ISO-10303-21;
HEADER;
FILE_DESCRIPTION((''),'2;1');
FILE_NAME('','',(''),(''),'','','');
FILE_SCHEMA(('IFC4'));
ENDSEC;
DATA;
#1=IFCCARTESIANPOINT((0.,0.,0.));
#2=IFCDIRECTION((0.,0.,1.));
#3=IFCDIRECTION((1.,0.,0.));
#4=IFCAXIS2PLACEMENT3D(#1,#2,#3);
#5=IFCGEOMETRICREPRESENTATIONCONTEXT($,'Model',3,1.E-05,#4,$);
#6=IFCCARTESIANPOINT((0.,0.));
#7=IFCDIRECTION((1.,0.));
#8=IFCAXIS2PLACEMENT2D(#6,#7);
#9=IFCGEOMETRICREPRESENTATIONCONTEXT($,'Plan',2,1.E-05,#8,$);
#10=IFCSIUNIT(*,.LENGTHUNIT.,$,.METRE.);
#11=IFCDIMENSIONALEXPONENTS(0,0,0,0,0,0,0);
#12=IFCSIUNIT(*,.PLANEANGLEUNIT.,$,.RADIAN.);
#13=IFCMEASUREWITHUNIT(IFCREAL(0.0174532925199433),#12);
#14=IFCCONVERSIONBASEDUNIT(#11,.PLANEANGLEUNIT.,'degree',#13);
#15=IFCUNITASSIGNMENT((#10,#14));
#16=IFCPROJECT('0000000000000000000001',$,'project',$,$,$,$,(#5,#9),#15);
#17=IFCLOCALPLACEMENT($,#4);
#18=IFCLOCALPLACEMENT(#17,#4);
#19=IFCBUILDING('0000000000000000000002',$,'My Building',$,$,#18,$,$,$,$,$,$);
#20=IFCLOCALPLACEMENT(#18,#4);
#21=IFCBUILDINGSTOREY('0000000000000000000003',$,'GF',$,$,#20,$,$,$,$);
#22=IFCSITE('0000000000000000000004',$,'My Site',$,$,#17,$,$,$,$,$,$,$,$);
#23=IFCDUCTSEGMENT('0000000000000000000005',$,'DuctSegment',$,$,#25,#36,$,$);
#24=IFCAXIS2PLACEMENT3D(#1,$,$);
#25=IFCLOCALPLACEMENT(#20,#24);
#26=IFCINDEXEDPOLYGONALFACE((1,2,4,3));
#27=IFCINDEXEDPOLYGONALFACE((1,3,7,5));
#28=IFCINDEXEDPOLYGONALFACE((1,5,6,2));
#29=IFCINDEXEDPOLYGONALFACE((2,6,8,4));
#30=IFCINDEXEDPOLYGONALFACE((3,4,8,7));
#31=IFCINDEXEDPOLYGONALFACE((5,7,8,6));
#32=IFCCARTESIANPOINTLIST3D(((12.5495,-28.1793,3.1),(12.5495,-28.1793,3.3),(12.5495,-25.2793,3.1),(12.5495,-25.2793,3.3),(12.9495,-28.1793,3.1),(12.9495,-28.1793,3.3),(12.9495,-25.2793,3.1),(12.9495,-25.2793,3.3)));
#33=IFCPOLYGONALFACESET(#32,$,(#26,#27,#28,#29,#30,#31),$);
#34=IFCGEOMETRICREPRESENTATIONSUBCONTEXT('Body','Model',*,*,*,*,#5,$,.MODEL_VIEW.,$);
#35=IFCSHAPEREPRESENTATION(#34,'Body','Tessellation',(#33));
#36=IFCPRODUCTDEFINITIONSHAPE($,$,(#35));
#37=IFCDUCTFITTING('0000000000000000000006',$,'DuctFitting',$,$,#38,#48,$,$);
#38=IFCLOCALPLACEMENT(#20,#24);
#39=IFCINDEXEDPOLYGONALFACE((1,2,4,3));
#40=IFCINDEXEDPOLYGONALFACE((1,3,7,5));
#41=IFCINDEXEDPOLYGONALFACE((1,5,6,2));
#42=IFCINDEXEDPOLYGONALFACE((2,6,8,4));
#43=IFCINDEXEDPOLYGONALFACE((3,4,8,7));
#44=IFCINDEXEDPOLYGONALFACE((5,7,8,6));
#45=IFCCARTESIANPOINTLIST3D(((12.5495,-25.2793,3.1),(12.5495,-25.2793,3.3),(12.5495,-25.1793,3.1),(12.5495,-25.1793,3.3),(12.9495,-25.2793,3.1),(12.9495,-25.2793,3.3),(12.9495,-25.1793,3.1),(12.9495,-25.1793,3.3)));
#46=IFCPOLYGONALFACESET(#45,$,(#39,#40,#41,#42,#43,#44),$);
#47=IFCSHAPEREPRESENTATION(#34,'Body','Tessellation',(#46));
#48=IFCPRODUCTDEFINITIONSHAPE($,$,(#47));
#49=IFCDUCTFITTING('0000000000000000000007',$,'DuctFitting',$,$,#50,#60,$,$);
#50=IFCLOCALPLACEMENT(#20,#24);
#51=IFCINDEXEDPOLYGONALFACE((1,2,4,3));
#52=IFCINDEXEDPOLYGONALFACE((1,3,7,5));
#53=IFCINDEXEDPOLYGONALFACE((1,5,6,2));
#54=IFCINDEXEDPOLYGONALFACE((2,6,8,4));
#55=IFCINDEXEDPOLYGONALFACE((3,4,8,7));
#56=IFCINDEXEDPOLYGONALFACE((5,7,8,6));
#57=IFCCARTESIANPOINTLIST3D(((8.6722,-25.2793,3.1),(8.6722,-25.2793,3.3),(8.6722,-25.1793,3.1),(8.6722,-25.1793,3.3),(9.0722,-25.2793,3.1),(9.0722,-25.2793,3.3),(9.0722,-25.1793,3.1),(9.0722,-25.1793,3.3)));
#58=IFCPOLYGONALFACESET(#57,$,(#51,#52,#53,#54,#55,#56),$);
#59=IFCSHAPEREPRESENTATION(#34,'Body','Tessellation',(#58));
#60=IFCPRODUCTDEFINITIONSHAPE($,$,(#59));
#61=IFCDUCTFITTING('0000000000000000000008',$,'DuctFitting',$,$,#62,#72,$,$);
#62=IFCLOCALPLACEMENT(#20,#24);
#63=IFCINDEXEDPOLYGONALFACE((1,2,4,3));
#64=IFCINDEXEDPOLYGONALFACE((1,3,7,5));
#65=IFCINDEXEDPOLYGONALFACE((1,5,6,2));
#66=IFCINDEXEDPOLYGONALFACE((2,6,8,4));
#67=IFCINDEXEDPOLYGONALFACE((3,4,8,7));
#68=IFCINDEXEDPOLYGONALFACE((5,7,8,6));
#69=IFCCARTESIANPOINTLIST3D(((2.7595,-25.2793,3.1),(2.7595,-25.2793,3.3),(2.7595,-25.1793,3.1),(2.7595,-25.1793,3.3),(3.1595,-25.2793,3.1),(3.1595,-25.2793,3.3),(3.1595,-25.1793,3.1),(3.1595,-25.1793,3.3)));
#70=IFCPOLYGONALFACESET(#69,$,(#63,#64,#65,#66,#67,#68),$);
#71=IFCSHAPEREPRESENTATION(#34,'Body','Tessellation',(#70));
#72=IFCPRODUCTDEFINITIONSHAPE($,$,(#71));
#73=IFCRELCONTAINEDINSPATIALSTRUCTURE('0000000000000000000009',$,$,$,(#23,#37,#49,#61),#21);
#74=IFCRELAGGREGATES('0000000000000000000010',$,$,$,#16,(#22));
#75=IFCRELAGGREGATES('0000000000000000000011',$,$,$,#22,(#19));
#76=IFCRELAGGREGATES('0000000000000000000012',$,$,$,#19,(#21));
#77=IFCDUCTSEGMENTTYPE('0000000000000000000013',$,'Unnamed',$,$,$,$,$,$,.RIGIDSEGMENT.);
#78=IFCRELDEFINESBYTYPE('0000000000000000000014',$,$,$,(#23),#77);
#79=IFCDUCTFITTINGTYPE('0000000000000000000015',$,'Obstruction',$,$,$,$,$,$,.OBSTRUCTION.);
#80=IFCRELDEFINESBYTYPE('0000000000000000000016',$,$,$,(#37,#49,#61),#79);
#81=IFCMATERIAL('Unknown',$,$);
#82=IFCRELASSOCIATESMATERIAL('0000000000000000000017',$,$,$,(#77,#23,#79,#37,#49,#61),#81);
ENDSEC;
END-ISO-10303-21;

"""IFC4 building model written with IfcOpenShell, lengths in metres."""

from ifc_helpers import new_model, entity, si_unit, converted_unit, frame, origin_with_axes, origin_2d_with_axis, place, context, subcontext, project, spatial, rectangle, extrude, material, material_profile, profile_set, profile_usage, type_object, element, save


model = new_model("IFC4")

# Units and contexts
model_context = context("Model", 3, precision=1e-05, world=origin_with_axes())
plan_context = context("Plan", 2, precision=1e-05, world=origin_2d_with_axis())
body_context_1 = subcontext(model_context, "Body", "Model", "MODEL_VIEW")
ifc_project = project(units=[si_unit("LENGTHUNIT", "METRE"), converted_unit("PLANEANGLEUNIT", "degree", entity("IfcReal", 0.0174532925199433), si_unit("PLANEANGLEUNIT", "RADIAN"), dimensions=[0, 0, 0, 0, 0, 0, 0])], contexts=[model_context, plan_context])

# Site, building, storey
site_placement = place(None, origin_with_axes())
site = spatial("IfcSite", under=ifc_project, at=site_placement, Name="My Site")
building_placement = place(site_placement, origin_with_axes())
building = spatial("IfcBuilding", under=site, at=building_placement, Name="My Building")
storey_placement = place(building_placement, origin_with_axes())
storey = spatial("IfcBuildingStorey", under=building, at=storey_placement, Name="GF")

# Shared definitions
ifc_material = material(Name="Unknown")

# Duct segment
ifc_material_profile_1 = material_profile(ifc_material, rectangle(XDim=0.4, YDim=0.2))
ifc_profile_set_1 = profile_set([ifc_material_profile_1])
duct_segment_type = type_object("IfcDuctSegmentType", Name="Unnamed", PredefinedType="RIGIDSEGMENT", material=ifc_profile_set_1)
ifc_profile_usage_1 = profile_usage(ifc_profile_set_1, cardinal=5)
duct_segment_1_placement = place(storey_placement, frame((12.7495, -25.2793, 3.2), z_axis=(0.0, -1.0, 0.0), x_axis=(1.0, 0.0, 0.0)))
element("IfcDuctSegment", 1, at=duct_segment_1_placement, inside=storey, type_object=duct_segment_type, material=ifc_profile_usage_1, Name="DuctSegment", context=body_context_1, shape_type="SweptSolid", body=[
    extrude(rectangle(XDim=0.4, YDim=0.2), origin_with_axes(), (0.0, 0.0, 1.0), 2.9),
])

# Duct fittings
ifc_material_profile_2 = material_profile(ifc_material, rectangle(XDim=0.4, YDim=0.2))
ifc_profile_set_2 = profile_set([ifc_material_profile_2])
ifc_profile_usage_2 = profile_usage(ifc_profile_set_2, cardinal=5)
duct_fitting_type = type_object("IfcDuctFittingType", Name="Obstruction", PredefinedType="OBSTRUCTION", material=ifc_profile_set_2)
duct_fitting_1_placement = place(storey_placement, frame((12.7495, -25.1793, 3.2), z_axis=(0.0, -1.0, 0.0), x_axis=(1.0, 0.0, 0.0)))
element("IfcDuctFitting", 2, at=duct_fitting_1_placement, inside=storey, type_object=duct_fitting_type, material=ifc_profile_usage_2, Name="DuctFitting", context=body_context_1, shape_type="SweptSolid", body=[
    extrude(rectangle(XDim=0.4, YDim=0.2), origin_with_axes(), (0.0, 0.0, 1.0), 0.1),
])
ifc_profile_usage_3 = profile_usage(ifc_profile_set_2, cardinal=5)
duct_fitting_2_placement = place(storey_placement, frame((8.8722, -25.1793, 3.2), z_axis=(0.0, -1.0, 0.0), x_axis=(1.0, 0.0, 0.0)))
element("IfcDuctFitting", 3, at=duct_fitting_2_placement, inside=storey, type_object=duct_fitting_type, material=ifc_profile_usage_3, Name="DuctFitting", context=body_context_1, shape_type="SweptSolid", body=[
    extrude(rectangle(XDim=0.4, YDim=0.2), origin_with_axes(), (0.0, 0.0, 1.0), 0.1),
])
ifc_profile_usage_4 = profile_usage(ifc_profile_set_2, cardinal=5)
duct_fitting_3_placement = place(storey_placement, frame((2.9595, -25.1793, 3.2), z_axis=(0.0, -1.0, 0.0), x_axis=(1.0, 0.0, 0.0)))
element("IfcDuctFitting", 4, at=duct_fitting_3_placement, inside=storey, type_object=duct_fitting_type, material=ifc_profile_usage_4, Name="DuctFitting", context=body_context_1, shape_type="SweptSolid", body=[
    extrude(rectangle(XDim=0.4, YDim=0.2), origin_with_axes(), (0.0, 0.0, 1.0), 0.1),
])

save(model, "model.ifc")
